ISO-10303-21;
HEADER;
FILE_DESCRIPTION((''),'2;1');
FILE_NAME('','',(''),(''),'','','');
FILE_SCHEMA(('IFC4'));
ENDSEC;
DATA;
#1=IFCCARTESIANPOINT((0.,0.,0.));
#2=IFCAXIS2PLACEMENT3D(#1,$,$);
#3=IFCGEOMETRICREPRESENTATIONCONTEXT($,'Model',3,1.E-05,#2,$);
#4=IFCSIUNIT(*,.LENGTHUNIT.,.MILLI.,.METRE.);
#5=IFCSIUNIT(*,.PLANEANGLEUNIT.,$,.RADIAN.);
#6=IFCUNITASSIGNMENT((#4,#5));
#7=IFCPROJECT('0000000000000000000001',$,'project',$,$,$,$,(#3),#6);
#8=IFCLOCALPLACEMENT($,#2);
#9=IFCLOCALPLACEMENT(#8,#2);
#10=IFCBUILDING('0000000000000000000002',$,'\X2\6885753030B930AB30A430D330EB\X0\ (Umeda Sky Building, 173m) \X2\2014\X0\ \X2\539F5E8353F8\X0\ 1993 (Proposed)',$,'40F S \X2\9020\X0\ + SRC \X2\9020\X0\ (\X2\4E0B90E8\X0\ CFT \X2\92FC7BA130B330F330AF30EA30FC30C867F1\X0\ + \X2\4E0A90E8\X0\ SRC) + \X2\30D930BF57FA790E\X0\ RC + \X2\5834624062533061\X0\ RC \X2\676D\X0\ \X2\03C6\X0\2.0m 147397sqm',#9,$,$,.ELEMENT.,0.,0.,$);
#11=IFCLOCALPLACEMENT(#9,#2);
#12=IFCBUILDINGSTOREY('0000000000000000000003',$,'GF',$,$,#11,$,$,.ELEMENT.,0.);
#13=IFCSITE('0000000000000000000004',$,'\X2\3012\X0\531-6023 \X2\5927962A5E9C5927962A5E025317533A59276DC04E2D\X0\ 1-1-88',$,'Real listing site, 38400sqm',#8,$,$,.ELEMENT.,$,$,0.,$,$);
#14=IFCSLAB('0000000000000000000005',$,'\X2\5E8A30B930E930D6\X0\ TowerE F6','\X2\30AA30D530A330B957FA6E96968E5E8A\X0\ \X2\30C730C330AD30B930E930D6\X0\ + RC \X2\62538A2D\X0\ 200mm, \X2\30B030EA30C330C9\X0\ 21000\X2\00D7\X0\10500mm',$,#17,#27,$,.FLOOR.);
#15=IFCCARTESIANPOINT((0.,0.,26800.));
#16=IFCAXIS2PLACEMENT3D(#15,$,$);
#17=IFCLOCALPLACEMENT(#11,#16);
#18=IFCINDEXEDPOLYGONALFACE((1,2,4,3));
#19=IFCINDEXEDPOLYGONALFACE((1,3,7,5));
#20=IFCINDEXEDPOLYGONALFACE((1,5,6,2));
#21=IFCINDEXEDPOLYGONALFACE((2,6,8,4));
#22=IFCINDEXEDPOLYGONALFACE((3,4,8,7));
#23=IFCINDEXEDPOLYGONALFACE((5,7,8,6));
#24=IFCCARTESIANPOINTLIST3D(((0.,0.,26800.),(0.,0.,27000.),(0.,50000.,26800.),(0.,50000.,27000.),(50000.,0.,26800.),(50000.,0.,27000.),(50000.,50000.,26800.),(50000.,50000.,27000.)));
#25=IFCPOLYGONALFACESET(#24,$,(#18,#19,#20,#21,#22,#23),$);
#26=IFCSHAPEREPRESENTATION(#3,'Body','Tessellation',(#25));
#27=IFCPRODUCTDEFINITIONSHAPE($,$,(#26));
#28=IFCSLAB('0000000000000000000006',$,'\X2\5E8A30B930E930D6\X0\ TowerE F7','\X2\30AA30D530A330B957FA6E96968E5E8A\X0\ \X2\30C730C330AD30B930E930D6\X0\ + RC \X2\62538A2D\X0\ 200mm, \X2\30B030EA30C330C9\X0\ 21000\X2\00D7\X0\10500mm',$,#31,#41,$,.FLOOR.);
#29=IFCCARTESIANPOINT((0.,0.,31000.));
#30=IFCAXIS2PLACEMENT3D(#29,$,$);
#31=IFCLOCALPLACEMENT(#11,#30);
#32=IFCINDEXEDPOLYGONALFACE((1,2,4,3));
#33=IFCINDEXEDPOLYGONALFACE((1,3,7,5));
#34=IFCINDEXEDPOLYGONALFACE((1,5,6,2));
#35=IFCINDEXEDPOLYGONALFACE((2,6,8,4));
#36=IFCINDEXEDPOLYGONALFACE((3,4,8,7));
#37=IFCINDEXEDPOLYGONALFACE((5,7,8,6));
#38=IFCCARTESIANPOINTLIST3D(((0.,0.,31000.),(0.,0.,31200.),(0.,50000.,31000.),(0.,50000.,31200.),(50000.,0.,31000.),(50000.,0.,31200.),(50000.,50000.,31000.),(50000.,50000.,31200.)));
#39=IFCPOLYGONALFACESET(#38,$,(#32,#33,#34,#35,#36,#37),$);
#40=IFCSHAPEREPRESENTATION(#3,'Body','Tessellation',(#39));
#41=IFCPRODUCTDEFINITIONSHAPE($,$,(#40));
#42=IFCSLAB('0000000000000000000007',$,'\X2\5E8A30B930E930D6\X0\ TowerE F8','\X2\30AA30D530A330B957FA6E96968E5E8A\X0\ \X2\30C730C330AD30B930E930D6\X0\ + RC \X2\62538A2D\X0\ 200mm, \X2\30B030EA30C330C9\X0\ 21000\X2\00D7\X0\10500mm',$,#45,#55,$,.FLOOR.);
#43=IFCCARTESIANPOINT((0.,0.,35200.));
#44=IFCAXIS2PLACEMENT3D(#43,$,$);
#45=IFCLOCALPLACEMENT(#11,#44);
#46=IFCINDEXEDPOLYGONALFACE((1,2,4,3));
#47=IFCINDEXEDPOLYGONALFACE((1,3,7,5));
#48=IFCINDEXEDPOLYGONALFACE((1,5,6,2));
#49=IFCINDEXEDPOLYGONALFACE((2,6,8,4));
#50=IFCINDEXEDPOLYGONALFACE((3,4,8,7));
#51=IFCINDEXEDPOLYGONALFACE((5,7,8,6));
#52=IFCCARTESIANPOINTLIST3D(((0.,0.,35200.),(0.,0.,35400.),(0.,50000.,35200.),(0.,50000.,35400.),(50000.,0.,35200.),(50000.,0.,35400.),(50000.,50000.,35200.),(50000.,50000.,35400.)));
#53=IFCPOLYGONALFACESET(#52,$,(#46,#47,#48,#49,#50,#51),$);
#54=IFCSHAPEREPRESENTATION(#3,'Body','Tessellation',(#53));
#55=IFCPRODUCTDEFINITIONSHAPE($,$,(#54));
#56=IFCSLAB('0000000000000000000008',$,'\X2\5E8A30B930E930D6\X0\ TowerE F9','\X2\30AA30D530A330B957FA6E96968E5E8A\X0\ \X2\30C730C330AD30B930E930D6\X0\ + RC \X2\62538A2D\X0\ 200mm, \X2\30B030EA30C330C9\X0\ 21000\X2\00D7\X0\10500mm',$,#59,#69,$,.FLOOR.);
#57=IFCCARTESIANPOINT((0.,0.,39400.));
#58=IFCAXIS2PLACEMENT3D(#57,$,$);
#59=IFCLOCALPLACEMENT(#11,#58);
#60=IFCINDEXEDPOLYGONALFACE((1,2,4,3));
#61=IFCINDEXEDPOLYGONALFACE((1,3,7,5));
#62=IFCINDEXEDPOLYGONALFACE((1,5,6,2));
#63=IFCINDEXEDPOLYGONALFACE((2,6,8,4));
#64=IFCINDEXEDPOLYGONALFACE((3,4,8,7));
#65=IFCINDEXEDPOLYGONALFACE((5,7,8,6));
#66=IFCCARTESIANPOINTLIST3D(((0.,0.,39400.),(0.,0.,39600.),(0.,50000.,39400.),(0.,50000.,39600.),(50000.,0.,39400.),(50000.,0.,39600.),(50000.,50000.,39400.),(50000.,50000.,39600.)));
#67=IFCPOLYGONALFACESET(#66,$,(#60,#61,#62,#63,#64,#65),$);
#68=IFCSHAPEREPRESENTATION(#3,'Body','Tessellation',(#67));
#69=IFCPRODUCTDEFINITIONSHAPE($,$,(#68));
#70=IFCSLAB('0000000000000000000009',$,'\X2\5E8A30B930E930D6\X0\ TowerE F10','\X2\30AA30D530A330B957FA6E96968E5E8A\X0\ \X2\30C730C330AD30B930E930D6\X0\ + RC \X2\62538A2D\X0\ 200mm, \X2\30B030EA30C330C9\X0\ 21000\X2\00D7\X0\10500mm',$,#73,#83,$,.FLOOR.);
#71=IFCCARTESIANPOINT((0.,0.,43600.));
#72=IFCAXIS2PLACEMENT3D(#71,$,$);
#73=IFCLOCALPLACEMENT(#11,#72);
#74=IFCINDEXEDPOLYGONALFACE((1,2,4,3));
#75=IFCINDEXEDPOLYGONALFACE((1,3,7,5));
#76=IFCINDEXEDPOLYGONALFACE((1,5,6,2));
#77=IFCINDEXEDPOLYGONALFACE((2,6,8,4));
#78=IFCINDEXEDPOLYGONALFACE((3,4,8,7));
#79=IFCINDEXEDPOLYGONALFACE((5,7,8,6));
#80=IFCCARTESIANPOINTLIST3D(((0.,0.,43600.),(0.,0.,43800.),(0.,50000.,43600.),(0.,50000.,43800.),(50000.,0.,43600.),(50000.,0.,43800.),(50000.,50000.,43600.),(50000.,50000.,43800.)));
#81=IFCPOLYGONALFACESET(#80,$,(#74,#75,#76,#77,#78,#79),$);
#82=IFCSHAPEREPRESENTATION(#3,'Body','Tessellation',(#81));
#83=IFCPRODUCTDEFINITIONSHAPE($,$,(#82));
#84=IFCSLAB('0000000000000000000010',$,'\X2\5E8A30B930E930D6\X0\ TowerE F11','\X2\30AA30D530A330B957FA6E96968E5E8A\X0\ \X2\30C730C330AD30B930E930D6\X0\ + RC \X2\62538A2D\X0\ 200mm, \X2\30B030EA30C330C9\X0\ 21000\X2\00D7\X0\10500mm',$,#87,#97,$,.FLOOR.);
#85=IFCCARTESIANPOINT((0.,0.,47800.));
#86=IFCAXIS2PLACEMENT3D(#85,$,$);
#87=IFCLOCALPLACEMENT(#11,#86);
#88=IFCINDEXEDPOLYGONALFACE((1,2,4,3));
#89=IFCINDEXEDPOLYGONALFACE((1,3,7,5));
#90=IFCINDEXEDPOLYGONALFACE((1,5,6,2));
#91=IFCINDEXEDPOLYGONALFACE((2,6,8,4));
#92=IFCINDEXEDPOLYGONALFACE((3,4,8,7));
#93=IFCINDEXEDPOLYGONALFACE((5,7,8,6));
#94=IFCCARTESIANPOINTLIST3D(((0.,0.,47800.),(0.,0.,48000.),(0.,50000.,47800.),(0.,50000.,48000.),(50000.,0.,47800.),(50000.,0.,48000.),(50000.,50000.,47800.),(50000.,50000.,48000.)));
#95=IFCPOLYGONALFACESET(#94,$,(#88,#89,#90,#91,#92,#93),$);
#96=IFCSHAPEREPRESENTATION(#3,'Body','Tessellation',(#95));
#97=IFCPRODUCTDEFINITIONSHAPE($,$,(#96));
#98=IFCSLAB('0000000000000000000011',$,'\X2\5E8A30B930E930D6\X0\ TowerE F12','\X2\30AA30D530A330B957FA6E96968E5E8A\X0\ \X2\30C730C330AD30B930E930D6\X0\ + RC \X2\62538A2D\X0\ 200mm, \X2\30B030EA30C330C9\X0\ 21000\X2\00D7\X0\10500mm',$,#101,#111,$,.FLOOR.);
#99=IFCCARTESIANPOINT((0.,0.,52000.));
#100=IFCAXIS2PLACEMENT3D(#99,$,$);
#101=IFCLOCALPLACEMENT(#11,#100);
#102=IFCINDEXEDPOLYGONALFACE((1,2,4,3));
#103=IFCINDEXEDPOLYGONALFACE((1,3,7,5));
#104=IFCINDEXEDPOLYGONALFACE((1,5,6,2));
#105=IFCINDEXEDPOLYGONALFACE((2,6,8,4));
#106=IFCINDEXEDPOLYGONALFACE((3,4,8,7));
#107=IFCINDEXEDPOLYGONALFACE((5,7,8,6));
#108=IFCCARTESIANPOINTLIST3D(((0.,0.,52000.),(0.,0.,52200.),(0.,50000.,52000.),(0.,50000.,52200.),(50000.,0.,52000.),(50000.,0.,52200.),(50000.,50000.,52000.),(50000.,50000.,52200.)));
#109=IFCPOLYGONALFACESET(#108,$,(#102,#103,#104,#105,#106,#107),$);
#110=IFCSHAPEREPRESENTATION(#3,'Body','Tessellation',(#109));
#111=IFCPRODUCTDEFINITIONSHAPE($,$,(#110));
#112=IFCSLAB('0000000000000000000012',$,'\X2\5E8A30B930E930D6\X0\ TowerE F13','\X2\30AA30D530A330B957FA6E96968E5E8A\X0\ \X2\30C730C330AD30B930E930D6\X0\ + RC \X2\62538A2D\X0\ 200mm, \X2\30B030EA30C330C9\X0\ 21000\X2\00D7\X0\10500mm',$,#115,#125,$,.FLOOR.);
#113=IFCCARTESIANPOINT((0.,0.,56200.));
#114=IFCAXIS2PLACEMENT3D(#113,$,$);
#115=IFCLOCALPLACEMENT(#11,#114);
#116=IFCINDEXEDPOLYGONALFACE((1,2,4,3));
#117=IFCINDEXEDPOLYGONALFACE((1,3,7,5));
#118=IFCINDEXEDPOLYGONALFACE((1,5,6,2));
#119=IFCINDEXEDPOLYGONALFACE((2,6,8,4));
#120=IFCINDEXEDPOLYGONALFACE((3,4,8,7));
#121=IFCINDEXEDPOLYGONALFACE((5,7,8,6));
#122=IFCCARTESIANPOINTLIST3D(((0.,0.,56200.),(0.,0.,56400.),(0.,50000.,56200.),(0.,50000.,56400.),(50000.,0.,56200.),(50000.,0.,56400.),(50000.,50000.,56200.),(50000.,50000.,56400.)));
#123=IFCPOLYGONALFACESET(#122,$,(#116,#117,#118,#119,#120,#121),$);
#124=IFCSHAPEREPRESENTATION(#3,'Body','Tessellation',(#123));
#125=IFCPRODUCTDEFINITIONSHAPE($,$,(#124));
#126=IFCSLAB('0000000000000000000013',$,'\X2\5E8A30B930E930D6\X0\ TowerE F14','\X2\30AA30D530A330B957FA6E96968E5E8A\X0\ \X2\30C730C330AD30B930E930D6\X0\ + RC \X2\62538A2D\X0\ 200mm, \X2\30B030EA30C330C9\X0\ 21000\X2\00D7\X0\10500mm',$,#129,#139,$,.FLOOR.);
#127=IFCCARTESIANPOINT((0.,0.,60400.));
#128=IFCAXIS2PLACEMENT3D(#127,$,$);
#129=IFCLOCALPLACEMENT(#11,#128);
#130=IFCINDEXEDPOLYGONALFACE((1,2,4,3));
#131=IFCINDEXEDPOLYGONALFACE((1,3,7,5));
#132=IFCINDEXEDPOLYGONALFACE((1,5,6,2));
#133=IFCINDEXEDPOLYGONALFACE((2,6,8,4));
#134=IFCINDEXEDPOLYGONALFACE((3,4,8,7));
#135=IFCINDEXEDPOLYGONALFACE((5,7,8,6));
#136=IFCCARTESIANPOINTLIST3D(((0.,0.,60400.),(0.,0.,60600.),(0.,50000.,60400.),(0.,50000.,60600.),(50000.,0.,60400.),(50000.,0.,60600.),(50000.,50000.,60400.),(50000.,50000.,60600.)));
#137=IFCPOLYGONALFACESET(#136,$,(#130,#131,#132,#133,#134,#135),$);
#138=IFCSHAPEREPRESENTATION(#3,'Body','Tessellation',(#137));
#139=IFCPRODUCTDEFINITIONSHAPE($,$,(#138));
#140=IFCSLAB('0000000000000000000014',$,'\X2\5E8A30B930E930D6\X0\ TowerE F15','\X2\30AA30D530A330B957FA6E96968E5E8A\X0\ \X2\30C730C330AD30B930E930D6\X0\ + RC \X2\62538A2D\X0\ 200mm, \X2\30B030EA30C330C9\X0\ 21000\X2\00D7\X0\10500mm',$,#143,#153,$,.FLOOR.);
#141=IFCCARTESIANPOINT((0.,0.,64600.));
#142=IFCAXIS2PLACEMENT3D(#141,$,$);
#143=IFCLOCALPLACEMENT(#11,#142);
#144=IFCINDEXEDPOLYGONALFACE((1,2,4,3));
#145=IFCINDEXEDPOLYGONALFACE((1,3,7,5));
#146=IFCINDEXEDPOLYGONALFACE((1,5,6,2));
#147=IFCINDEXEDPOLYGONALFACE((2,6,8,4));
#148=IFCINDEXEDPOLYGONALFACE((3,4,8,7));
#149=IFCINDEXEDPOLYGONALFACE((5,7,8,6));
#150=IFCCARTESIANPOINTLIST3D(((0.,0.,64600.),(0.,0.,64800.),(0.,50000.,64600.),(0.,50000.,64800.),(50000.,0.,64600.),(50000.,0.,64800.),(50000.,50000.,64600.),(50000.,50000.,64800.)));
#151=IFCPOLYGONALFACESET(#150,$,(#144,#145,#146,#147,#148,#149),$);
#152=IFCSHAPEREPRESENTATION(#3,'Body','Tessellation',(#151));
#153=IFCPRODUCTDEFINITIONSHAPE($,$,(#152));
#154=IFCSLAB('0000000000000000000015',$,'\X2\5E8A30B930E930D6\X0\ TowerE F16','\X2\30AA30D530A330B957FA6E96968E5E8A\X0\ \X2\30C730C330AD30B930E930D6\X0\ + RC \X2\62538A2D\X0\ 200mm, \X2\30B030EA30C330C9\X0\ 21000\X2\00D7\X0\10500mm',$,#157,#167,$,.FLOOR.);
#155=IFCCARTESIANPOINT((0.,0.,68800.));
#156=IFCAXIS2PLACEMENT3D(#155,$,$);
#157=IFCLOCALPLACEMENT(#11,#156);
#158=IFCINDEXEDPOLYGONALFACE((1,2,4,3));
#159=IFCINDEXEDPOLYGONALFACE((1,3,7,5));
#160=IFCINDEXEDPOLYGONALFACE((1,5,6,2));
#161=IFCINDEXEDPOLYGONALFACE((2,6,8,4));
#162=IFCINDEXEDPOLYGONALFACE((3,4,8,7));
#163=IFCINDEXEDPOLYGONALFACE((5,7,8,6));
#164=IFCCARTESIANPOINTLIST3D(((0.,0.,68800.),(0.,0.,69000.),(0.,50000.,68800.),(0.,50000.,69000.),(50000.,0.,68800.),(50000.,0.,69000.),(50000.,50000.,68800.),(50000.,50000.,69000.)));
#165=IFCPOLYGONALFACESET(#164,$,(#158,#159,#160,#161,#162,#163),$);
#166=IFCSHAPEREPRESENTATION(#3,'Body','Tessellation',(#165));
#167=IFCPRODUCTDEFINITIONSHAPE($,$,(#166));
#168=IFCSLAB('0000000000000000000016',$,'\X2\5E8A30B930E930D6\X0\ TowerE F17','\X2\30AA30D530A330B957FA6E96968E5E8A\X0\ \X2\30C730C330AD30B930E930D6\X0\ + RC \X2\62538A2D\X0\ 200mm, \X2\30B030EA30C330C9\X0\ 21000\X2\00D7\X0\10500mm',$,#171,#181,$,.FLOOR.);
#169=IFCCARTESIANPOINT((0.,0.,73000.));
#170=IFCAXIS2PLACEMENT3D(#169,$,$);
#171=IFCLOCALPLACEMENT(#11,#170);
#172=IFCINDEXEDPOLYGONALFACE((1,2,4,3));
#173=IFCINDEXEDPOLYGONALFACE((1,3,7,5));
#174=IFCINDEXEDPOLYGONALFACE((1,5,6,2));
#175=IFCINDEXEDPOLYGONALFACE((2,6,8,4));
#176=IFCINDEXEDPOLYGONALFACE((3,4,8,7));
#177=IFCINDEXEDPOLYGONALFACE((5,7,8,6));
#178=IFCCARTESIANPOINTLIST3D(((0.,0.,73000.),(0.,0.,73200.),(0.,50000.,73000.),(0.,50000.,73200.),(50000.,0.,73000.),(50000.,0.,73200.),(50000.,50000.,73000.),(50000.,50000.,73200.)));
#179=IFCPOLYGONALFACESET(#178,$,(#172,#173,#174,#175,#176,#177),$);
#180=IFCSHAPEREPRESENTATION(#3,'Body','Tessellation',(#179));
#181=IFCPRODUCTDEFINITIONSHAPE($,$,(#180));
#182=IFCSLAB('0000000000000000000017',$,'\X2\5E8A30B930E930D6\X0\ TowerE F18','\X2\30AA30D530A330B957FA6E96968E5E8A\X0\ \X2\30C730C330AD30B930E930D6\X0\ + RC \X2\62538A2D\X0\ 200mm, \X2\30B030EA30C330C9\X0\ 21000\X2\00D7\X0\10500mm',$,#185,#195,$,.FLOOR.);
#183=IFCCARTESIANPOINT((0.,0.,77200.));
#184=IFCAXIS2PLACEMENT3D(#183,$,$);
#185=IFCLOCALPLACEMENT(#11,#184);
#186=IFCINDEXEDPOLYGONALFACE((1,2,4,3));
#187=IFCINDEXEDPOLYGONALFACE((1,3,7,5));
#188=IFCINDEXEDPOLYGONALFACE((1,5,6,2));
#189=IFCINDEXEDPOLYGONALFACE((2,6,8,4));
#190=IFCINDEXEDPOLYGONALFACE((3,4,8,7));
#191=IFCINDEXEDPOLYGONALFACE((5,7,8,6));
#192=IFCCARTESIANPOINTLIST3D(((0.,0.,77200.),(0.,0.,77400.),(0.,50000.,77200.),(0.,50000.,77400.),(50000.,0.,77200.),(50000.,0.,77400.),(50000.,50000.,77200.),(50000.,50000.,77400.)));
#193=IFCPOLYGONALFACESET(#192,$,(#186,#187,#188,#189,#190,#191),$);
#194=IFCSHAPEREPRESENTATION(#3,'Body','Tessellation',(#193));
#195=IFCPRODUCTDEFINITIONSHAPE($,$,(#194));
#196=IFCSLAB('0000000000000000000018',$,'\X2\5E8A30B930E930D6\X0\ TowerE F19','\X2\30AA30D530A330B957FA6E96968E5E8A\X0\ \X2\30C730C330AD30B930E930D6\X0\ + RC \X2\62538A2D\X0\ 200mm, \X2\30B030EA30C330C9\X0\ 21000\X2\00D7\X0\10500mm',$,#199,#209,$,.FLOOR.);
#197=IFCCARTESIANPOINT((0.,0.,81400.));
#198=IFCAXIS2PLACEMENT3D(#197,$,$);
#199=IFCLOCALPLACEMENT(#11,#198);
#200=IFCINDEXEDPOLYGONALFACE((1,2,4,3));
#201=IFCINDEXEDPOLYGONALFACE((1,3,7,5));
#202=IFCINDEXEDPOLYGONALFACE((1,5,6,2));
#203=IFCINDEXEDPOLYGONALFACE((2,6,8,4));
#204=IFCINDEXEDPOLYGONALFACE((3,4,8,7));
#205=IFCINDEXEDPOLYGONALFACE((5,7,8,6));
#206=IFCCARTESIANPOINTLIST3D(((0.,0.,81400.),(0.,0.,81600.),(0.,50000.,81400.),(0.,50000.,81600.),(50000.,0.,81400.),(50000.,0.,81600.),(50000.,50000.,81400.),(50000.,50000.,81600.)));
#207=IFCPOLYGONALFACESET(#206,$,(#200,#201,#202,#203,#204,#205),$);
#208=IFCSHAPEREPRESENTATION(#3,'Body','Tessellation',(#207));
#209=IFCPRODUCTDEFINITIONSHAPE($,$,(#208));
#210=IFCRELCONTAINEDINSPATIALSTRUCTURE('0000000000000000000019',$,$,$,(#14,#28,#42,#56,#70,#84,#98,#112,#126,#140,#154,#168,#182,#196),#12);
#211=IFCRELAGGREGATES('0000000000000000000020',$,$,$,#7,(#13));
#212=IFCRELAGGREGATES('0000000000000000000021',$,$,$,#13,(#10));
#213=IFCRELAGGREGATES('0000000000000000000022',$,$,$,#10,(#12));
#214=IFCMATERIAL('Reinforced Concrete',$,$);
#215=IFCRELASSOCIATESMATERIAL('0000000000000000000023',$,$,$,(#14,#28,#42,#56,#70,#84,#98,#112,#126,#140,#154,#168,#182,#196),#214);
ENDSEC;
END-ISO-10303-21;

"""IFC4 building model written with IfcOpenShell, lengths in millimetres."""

from ifc_helpers import new_model, si_unit, frame, frame_2d, origin, place, context, project, spatial, rectangle, extrude, material, element, save


model = new_model("IFC4")

# Units and contexts
model_context = context("Model", 3, precision=1e-05, world=origin())
ifc_project = project(units=[si_unit("LENGTHUNIT", "METRE", prefix="MILLI"), si_unit("PLANEANGLEUNIT", "RADIAN")], contexts=[model_context])

# Site, building, storey
site_placement = place(None, origin())
site = spatial("IfcSite", under=ifc_project, at=site_placement, Name="〒531-6023 大阪府大阪市北区大淀中 1-1-88", ObjectType="Real listing site, 38400sqm", CompositionType="ELEMENT", RefElevation=0.0)
building_placement = place(site_placement, origin())
building = spatial("IfcBuilding", under=site, at=building_placement, Name="梅田スカイビル (Umeda Sky Building, 173m) — 原広司 1993 (Proposed)", ObjectType="40F S 造 + SRC 造 (下部 CFT 鋼管コンクリート柱 + 上部 SRC) + ベタ基礎 RC + 場所打ち RC 杭 φ2.0m 147397sqm", CompositionType="ELEMENT", ElevationOfRefHeight=0.0, ElevationOfTerrain=0.0)
storey_placement = place(building_placement, origin())
storey = spatial("IfcBuildingStorey", under=building, at=storey_placement, Name="GF", CompositionType="ELEMENT", Elevation=0.0)

# Shared definitions
ifc_material_1 = material(Name="Reinforced Concrete")

# Slabs
slab_1_placement = place(storey_placement, frame((0.0, 0.0, 26800.0)))
element("IfcSlab", 1, at=slab_1_placement, inside=storey, material=ifc_material_1, Name="床スラブ TowerE F6", Description="オフィス基準階床 デッキスラブ + RC 打設 200mm, グリッド 21000×10500mm", PredefinedType="FLOOR", context=model_context, shape_type="SweptSolid", body=[
    extrude(rectangle(XDim=50000.0, YDim=50000.0, at=frame_2d((25000.0, 25000.0))), frame((0.0, 0.0, 26800.0)), (0.0, 0.0, 1.0), 200.0),
])
slab_2_placement = place(storey_placement, frame((0.0, 0.0, 31000.0)))
element("IfcSlab", 2, at=slab_2_placement, inside=storey, material=ifc_material_1, Name="床スラブ TowerE F7", Description="オフィス基準階床 デッキスラブ + RC 打設 200mm, グリッド 21000×10500mm", PredefinedType="FLOOR", context=model_context, shape_type="SweptSolid", body=[
    extrude(rectangle(XDim=50000.0, YDim=50000.0, at=frame_2d((25000.0, 25000.0))), frame((0.0, 0.0, 31000.0)), (0.0, 0.0, 1.0), 200.0),
])
slab_3_placement = place(storey_placement, frame((0.0, 0.0, 35200.0)))
element("IfcSlab", 3, at=slab_3_placement, inside=storey, material=ifc_material_1, Name="床スラブ TowerE F8", Description="オフィス基準階床 デッキスラブ + RC 打設 200mm, グリッド 21000×10500mm", PredefinedType="FLOOR", context=model_context, shape_type="SweptSolid", body=[
    extrude(rectangle(XDim=50000.0, YDim=50000.0, at=frame_2d((25000.0, 25000.0))), frame((0.0, 0.0, 35200.0)), (0.0, 0.0, 1.0), 200.0),
])
slab_4_placement = place(storey_placement, frame((0.0, 0.0, 39400.0)))
element("IfcSlab", 4, at=slab_4_placement, inside=storey, material=ifc_material_1, Name="床スラブ TowerE F9", Description="オフィス基準階床 デッキスラブ + RC 打設 200mm, グリッド 21000×10500mm", PredefinedType="FLOOR", context=model_context, shape_type="SweptSolid", body=[
    extrude(rectangle(XDim=50000.0, YDim=50000.0, at=frame_2d((25000.0, 25000.0))), frame((0.0, 0.0, 39400.0)), (0.0, 0.0, 1.0), 200.0),
])
slab_5_placement = place(storey_placement, frame((0.0, 0.0, 43600.0)))
element("IfcSlab", 5, at=slab_5_placement, inside=storey, material=ifc_material_1, Name="床スラブ TowerE F10", Description="オフィス基準階床 デッキスラブ + RC 打設 200mm, グリッド 21000×10500mm", PredefinedType="FLOOR", context=model_context, shape_type="SweptSolid", body=[
    extrude(rectangle(XDim=50000.0, YDim=50000.0, at=frame_2d((25000.0, 25000.0))), frame((0.0, 0.0, 43600.0)), (0.0, 0.0, 1.0), 200.0),
])
slab_6_placement = place(storey_placement, frame((0.0, 0.0, 47800.0)))
element("IfcSlab", 6, at=slab_6_placement, inside=storey, material=ifc_material_1, Name="床スラブ TowerE F11", Description="オフィス基準階床 デッキスラブ + RC 打設 200mm, グリッド 21000×10500mm", PredefinedType="FLOOR", context=model_context, shape_type="SweptSolid", body=[
    extrude(rectangle(XDim=50000.0, YDim=50000.0, at=frame_2d((25000.0, 25000.0))), frame((0.0, 0.0, 47800.0)), (0.0, 0.0, 1.0), 200.0),
])
slab_7_placement = place(storey_placement, frame((0.0, 0.0, 52000.0)))
element("IfcSlab", 7, at=slab_7_placement, inside=storey, material=ifc_material_1, Name="床スラブ TowerE F12", Description="オフィス基準階床 デッキスラブ + RC 打設 200mm, グリッド 21000×10500mm", PredefinedType="FLOOR", context=model_context, shape_type="SweptSolid", body=[
    extrude(rectangle(XDim=50000.0, YDim=50000.0, at=frame_2d((25000.0, 25000.0))), frame((0.0, 0.0, 52000.0)), (0.0, 0.0, 1.0), 200.0),
])
slab_8_placement = place(storey_placement, frame((0.0, 0.0, 56200.0)))
element("IfcSlab", 8, at=slab_8_placement, inside=storey, material=ifc_material_1, Name="床スラブ TowerE F13", Description="オフィス基準階床 デッキスラブ + RC 打設 200mm, グリッド 21000×10500mm", PredefinedType="FLOOR", context=model_context, shape_type="SweptSolid", body=[
    extrude(rectangle(XDim=50000.0, YDim=50000.0, at=frame_2d((25000.0, 25000.0))), frame((0.0, 0.0, 56200.0)), (0.0, 0.0, 1.0), 200.0),
])
slab_9_placement = place(storey_placement, frame((0.0, 0.0, 60400.0)))
element("IfcSlab", 9, at=slab_9_placement, inside=storey, material=ifc_material_1, Name="床スラブ TowerE F14", Description="オフィス基準階床 デッキスラブ + RC 打設 200mm, グリッド 21000×10500mm", PredefinedType="FLOOR", context=model_context, shape_type="SweptSolid", body=[
    extrude(rectangle(XDim=50000.0, YDim=50000.0, at=frame_2d((25000.0, 25000.0))), frame((0.0, 0.0, 60400.0)), (0.0, 0.0, 1.0), 200.0),
])
slab_10_placement = place(storey_placement, frame((0.0, 0.0, 64600.0)))
element("IfcSlab", 10, at=slab_10_placement, inside=storey, material=ifc_material_1, Name="床スラブ TowerE F15", Description="オフィス基準階床 デッキスラブ + RC 打設 200mm, グリッド 21000×10500mm", PredefinedType="FLOOR", context=model_context, shape_type="SweptSolid", body=[
    extrude(rectangle(XDim=50000.0, YDim=50000.0, at=frame_2d((25000.0, 25000.0))), frame((0.0, 0.0, 64600.0)), (0.0, 0.0, 1.0), 200.0),
])
slab_11_placement = place(storey_placement, frame((0.0, 0.0, 68800.0)))
element("IfcSlab", 11, at=slab_11_placement, inside=storey, material=ifc_material_1, Name="床スラブ TowerE F16", Description="オフィス基準階床 デッキスラブ + RC 打設 200mm, グリッド 21000×10500mm", PredefinedType="FLOOR", context=model_context, shape_type="SweptSolid", body=[
    extrude(rectangle(XDim=50000.0, YDim=50000.0, at=frame_2d((25000.0, 25000.0))), frame((0.0, 0.0, 68800.0)), (0.0, 0.0, 1.0), 200.0),
])
slab_12_placement = place(storey_placement, frame((0.0, 0.0, 73000.0)))
element("IfcSlab", 12, at=slab_12_placement, inside=storey, material=ifc_material_1, Name="床スラブ TowerE F17", Description="オフィス基準階床 デッキスラブ + RC 打設 200mm, グリッド 21000×10500mm", PredefinedType="FLOOR", context=model_context, shape_type="SweptSolid", body=[
    extrude(rectangle(XDim=50000.0, YDim=50000.0, at=frame_2d((25000.0, 25000.0))), frame((0.0, 0.0, 73000.0)), (0.0, 0.0, 1.0), 200.0),
])
slab_13_placement = place(storey_placement, frame((0.0, 0.0, 77200.0)))
element("IfcSlab", 13, at=slab_13_placement, inside=storey, material=ifc_material_1, Name="床スラブ TowerE F18", Description="オフィス基準階床 デッキスラブ + RC 打設 200mm, グリッド 21000×10500mm", PredefinedType="FLOOR", context=model_context, shape_type="SweptSolid", body=[
    extrude(rectangle(XDim=50000.0, YDim=50000.0, at=frame_2d((25000.0, 25000.0))), frame((0.0, 0.0, 77200.0)), (0.0, 0.0, 1.0), 200.0),
])
slab_14_placement = place(storey_placement, frame((0.0, 0.0, 81400.0)))
element("IfcSlab", 14, at=slab_14_placement, inside=storey, material=ifc_material_1, Name="床スラブ TowerE F19", Description="オフィス基準階床 デッキスラブ + RC 打設 200mm, グリッド 21000×10500mm", PredefinedType="FLOOR", context=model_context, shape_type="SweptSolid", body=[
    extrude(rectangle(XDim=50000.0, YDim=50000.0, at=frame_2d((25000.0, 25000.0))), frame((0.0, 0.0, 81400.0)), (0.0, 0.0, 1.0), 200.0),
])

save(model, "model.ifc")
